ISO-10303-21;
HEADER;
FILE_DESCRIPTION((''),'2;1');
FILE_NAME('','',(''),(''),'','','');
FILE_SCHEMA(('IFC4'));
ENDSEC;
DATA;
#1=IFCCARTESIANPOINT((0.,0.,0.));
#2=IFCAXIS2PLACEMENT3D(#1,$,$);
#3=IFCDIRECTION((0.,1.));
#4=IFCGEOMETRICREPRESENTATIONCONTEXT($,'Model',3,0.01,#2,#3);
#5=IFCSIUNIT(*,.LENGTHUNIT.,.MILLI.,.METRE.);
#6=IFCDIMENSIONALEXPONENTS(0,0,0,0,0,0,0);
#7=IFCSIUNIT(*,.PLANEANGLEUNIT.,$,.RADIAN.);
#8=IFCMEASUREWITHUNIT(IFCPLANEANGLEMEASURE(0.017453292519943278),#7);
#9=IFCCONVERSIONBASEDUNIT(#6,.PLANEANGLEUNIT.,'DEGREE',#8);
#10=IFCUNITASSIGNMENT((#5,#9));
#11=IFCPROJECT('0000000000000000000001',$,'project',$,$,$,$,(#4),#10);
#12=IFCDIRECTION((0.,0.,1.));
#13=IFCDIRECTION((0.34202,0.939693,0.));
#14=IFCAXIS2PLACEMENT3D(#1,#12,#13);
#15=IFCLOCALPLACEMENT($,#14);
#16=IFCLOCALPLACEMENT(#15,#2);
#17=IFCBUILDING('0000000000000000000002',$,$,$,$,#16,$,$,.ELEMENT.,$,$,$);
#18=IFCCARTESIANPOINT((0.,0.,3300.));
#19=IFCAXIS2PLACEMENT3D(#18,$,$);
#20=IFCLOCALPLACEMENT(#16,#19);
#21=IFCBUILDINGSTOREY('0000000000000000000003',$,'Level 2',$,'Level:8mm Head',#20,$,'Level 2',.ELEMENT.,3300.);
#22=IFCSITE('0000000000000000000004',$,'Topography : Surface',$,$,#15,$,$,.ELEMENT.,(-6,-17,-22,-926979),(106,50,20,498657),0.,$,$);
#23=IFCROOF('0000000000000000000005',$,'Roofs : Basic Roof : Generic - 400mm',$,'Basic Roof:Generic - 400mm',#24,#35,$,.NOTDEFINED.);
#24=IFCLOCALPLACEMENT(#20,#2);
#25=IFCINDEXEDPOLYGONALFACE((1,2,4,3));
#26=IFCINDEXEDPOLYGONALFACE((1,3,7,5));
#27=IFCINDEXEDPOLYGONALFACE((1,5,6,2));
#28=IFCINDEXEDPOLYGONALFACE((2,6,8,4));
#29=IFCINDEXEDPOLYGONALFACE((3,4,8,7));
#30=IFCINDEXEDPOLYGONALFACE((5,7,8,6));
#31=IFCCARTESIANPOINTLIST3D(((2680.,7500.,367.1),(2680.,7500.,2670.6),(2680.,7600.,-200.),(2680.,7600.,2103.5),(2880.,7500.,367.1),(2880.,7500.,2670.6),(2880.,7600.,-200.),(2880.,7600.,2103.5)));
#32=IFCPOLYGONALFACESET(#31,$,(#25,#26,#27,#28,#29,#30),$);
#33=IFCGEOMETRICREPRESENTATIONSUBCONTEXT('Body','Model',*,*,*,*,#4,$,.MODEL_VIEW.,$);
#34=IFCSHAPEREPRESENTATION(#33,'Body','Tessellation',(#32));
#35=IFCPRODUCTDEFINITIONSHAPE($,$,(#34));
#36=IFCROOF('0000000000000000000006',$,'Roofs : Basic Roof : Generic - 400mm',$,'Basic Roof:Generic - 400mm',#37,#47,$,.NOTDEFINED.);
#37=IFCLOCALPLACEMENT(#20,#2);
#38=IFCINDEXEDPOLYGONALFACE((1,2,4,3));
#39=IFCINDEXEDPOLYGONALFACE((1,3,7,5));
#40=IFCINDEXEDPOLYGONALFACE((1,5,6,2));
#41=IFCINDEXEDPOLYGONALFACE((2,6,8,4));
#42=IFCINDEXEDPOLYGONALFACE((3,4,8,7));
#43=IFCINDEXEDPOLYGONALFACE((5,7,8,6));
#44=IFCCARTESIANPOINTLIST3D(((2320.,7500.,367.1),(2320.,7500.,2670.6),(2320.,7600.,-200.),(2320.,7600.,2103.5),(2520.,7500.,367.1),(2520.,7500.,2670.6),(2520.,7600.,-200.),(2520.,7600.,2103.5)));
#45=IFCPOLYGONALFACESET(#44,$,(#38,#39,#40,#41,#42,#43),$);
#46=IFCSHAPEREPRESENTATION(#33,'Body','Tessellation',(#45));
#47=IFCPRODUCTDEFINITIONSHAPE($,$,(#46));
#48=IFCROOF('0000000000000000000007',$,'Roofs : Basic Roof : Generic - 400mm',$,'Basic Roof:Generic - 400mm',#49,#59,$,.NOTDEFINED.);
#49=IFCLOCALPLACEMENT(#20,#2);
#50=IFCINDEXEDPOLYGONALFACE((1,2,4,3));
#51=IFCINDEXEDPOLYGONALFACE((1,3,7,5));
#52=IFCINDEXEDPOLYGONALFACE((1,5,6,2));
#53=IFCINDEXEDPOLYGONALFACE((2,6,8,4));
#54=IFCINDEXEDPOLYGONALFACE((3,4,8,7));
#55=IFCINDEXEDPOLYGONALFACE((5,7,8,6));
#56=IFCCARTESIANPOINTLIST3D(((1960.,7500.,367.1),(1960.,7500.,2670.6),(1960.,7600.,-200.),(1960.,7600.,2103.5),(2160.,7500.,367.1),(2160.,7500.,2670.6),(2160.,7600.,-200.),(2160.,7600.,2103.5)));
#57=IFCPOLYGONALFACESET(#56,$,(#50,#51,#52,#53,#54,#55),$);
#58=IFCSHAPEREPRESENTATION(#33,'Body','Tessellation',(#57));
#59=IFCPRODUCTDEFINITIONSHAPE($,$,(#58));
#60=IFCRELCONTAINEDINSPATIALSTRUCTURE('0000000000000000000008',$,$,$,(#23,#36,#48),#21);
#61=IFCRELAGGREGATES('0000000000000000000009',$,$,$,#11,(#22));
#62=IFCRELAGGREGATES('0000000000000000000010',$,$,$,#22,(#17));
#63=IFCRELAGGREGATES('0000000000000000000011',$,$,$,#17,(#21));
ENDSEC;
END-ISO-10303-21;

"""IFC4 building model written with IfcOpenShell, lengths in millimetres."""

from ifc_helpers import new_model, entity, si_unit, converted_unit, direction, frame, origin, place, context, subcontext, project, spatial, indexed_curve, outline, extrude, element, save


model = new_model("IFC4")

# Units and contexts
model_context = context("Model", 3, precision=0.01, world=origin(), true_north=direction((0.0, 1.0)))
body_context = subcontext(model_context, "Body", "Model", "MODEL_VIEW")
ifc_project = project(units=[si_unit("LENGTHUNIT", "METRE", prefix="MILLI"), converted_unit("PLANEANGLEUNIT", "DEGREE", entity("IfcPlaneAngleMeasure", 0.017453292519943278), si_unit("PLANEANGLEUNIT", "RADIAN"), dimensions=[0, 0, 0, 0, 0, 0, 0])], contexts=[model_context])

# Site, building, storey
site_placement = place(None, frame((0.0, 0.0, 0.0), z_axis=(0.0, 0.0, 1.0), x_axis=(0.34202, 0.939693, 0.0)))
site = spatial("IfcSite", under=ifc_project, at=site_placement, Name="Topography : Surface", CompositionType="ELEMENT", RefLatitude=(-6, -17, -22, -926979), RefLongitude=(106, 50, 20, 498657), RefElevation=0.0)
building_placement = place(site_placement, origin())
building = spatial("IfcBuilding", under=site, at=building_placement, CompositionType="ELEMENT")
storey_placement = place(building_placement, frame((0.0, 0.0, 3300.0)))
storey = spatial("IfcBuildingStorey", under=building, at=storey_placement, Name="Level 2", ObjectType="Level:8mm Head", LongName="Level 2", CompositionType="ELEMENT", Elevation=3300.0)

# Roofs
for number, where, name in (
    (1, (2680.0, 7500.0, -200.0), "Roofs : Basic Roof : Generic - 400mm"),
):
    element("IfcRoof", number, at=place(storey_placement, frame(where)), inside=storey, Name=name, ObjectType="Basic Roof:Generic - 400mm", PredefinedType="NOTDEFINED", context=body_context, shape_type="SweptSolid", body=[
        extrude(outline(indexed_curve([(100.0, 287.9), (-100.0, 287.9), (-100.0, -287.9), (100.0, -287.9), (100.0, 287.9)], self_intersect=False)), frame((100.0, 50.0, 283.6), z_axis=(0.0, 0.984808, 0.173648), x_axis=(1.0, 0.0, 0.0)), (0.0, -0.984808, 0.173648), 2303.5),
    ])
for number, where, name in (
    (2, (2320.0, 7500.0, -200.0), "Roofs : Basic Roof : Generic - 400mm"),
    (3, (1960.0, 7500.0, -200.0), "Roofs : Basic Roof : Generic - 400mm"),
):
    element("IfcRoof", number, at=place(storey_placement, frame(where)), inside=storey, Name=name, ObjectType="Basic Roof:Generic - 400mm", PredefinedType="NOTDEFINED", context=body_context, shape_type="SweptSolid", body=[
        extrude(outline(indexed_curve([(100.0, 287.9), (-100.0, 287.9), (-100.0, -287.9), (100.0, -287.9), (100.0, 287.9)], self_intersect=False)), frame((100.0, 50.0, 283.6), z_axis=(0.0, 0.984808, 0.173648), x_axis=(1.0, 0.0, 0.0)), (0.0, -0.984808, 0.173648), 2303.5),
    ])

save(model, "model.ifc")
